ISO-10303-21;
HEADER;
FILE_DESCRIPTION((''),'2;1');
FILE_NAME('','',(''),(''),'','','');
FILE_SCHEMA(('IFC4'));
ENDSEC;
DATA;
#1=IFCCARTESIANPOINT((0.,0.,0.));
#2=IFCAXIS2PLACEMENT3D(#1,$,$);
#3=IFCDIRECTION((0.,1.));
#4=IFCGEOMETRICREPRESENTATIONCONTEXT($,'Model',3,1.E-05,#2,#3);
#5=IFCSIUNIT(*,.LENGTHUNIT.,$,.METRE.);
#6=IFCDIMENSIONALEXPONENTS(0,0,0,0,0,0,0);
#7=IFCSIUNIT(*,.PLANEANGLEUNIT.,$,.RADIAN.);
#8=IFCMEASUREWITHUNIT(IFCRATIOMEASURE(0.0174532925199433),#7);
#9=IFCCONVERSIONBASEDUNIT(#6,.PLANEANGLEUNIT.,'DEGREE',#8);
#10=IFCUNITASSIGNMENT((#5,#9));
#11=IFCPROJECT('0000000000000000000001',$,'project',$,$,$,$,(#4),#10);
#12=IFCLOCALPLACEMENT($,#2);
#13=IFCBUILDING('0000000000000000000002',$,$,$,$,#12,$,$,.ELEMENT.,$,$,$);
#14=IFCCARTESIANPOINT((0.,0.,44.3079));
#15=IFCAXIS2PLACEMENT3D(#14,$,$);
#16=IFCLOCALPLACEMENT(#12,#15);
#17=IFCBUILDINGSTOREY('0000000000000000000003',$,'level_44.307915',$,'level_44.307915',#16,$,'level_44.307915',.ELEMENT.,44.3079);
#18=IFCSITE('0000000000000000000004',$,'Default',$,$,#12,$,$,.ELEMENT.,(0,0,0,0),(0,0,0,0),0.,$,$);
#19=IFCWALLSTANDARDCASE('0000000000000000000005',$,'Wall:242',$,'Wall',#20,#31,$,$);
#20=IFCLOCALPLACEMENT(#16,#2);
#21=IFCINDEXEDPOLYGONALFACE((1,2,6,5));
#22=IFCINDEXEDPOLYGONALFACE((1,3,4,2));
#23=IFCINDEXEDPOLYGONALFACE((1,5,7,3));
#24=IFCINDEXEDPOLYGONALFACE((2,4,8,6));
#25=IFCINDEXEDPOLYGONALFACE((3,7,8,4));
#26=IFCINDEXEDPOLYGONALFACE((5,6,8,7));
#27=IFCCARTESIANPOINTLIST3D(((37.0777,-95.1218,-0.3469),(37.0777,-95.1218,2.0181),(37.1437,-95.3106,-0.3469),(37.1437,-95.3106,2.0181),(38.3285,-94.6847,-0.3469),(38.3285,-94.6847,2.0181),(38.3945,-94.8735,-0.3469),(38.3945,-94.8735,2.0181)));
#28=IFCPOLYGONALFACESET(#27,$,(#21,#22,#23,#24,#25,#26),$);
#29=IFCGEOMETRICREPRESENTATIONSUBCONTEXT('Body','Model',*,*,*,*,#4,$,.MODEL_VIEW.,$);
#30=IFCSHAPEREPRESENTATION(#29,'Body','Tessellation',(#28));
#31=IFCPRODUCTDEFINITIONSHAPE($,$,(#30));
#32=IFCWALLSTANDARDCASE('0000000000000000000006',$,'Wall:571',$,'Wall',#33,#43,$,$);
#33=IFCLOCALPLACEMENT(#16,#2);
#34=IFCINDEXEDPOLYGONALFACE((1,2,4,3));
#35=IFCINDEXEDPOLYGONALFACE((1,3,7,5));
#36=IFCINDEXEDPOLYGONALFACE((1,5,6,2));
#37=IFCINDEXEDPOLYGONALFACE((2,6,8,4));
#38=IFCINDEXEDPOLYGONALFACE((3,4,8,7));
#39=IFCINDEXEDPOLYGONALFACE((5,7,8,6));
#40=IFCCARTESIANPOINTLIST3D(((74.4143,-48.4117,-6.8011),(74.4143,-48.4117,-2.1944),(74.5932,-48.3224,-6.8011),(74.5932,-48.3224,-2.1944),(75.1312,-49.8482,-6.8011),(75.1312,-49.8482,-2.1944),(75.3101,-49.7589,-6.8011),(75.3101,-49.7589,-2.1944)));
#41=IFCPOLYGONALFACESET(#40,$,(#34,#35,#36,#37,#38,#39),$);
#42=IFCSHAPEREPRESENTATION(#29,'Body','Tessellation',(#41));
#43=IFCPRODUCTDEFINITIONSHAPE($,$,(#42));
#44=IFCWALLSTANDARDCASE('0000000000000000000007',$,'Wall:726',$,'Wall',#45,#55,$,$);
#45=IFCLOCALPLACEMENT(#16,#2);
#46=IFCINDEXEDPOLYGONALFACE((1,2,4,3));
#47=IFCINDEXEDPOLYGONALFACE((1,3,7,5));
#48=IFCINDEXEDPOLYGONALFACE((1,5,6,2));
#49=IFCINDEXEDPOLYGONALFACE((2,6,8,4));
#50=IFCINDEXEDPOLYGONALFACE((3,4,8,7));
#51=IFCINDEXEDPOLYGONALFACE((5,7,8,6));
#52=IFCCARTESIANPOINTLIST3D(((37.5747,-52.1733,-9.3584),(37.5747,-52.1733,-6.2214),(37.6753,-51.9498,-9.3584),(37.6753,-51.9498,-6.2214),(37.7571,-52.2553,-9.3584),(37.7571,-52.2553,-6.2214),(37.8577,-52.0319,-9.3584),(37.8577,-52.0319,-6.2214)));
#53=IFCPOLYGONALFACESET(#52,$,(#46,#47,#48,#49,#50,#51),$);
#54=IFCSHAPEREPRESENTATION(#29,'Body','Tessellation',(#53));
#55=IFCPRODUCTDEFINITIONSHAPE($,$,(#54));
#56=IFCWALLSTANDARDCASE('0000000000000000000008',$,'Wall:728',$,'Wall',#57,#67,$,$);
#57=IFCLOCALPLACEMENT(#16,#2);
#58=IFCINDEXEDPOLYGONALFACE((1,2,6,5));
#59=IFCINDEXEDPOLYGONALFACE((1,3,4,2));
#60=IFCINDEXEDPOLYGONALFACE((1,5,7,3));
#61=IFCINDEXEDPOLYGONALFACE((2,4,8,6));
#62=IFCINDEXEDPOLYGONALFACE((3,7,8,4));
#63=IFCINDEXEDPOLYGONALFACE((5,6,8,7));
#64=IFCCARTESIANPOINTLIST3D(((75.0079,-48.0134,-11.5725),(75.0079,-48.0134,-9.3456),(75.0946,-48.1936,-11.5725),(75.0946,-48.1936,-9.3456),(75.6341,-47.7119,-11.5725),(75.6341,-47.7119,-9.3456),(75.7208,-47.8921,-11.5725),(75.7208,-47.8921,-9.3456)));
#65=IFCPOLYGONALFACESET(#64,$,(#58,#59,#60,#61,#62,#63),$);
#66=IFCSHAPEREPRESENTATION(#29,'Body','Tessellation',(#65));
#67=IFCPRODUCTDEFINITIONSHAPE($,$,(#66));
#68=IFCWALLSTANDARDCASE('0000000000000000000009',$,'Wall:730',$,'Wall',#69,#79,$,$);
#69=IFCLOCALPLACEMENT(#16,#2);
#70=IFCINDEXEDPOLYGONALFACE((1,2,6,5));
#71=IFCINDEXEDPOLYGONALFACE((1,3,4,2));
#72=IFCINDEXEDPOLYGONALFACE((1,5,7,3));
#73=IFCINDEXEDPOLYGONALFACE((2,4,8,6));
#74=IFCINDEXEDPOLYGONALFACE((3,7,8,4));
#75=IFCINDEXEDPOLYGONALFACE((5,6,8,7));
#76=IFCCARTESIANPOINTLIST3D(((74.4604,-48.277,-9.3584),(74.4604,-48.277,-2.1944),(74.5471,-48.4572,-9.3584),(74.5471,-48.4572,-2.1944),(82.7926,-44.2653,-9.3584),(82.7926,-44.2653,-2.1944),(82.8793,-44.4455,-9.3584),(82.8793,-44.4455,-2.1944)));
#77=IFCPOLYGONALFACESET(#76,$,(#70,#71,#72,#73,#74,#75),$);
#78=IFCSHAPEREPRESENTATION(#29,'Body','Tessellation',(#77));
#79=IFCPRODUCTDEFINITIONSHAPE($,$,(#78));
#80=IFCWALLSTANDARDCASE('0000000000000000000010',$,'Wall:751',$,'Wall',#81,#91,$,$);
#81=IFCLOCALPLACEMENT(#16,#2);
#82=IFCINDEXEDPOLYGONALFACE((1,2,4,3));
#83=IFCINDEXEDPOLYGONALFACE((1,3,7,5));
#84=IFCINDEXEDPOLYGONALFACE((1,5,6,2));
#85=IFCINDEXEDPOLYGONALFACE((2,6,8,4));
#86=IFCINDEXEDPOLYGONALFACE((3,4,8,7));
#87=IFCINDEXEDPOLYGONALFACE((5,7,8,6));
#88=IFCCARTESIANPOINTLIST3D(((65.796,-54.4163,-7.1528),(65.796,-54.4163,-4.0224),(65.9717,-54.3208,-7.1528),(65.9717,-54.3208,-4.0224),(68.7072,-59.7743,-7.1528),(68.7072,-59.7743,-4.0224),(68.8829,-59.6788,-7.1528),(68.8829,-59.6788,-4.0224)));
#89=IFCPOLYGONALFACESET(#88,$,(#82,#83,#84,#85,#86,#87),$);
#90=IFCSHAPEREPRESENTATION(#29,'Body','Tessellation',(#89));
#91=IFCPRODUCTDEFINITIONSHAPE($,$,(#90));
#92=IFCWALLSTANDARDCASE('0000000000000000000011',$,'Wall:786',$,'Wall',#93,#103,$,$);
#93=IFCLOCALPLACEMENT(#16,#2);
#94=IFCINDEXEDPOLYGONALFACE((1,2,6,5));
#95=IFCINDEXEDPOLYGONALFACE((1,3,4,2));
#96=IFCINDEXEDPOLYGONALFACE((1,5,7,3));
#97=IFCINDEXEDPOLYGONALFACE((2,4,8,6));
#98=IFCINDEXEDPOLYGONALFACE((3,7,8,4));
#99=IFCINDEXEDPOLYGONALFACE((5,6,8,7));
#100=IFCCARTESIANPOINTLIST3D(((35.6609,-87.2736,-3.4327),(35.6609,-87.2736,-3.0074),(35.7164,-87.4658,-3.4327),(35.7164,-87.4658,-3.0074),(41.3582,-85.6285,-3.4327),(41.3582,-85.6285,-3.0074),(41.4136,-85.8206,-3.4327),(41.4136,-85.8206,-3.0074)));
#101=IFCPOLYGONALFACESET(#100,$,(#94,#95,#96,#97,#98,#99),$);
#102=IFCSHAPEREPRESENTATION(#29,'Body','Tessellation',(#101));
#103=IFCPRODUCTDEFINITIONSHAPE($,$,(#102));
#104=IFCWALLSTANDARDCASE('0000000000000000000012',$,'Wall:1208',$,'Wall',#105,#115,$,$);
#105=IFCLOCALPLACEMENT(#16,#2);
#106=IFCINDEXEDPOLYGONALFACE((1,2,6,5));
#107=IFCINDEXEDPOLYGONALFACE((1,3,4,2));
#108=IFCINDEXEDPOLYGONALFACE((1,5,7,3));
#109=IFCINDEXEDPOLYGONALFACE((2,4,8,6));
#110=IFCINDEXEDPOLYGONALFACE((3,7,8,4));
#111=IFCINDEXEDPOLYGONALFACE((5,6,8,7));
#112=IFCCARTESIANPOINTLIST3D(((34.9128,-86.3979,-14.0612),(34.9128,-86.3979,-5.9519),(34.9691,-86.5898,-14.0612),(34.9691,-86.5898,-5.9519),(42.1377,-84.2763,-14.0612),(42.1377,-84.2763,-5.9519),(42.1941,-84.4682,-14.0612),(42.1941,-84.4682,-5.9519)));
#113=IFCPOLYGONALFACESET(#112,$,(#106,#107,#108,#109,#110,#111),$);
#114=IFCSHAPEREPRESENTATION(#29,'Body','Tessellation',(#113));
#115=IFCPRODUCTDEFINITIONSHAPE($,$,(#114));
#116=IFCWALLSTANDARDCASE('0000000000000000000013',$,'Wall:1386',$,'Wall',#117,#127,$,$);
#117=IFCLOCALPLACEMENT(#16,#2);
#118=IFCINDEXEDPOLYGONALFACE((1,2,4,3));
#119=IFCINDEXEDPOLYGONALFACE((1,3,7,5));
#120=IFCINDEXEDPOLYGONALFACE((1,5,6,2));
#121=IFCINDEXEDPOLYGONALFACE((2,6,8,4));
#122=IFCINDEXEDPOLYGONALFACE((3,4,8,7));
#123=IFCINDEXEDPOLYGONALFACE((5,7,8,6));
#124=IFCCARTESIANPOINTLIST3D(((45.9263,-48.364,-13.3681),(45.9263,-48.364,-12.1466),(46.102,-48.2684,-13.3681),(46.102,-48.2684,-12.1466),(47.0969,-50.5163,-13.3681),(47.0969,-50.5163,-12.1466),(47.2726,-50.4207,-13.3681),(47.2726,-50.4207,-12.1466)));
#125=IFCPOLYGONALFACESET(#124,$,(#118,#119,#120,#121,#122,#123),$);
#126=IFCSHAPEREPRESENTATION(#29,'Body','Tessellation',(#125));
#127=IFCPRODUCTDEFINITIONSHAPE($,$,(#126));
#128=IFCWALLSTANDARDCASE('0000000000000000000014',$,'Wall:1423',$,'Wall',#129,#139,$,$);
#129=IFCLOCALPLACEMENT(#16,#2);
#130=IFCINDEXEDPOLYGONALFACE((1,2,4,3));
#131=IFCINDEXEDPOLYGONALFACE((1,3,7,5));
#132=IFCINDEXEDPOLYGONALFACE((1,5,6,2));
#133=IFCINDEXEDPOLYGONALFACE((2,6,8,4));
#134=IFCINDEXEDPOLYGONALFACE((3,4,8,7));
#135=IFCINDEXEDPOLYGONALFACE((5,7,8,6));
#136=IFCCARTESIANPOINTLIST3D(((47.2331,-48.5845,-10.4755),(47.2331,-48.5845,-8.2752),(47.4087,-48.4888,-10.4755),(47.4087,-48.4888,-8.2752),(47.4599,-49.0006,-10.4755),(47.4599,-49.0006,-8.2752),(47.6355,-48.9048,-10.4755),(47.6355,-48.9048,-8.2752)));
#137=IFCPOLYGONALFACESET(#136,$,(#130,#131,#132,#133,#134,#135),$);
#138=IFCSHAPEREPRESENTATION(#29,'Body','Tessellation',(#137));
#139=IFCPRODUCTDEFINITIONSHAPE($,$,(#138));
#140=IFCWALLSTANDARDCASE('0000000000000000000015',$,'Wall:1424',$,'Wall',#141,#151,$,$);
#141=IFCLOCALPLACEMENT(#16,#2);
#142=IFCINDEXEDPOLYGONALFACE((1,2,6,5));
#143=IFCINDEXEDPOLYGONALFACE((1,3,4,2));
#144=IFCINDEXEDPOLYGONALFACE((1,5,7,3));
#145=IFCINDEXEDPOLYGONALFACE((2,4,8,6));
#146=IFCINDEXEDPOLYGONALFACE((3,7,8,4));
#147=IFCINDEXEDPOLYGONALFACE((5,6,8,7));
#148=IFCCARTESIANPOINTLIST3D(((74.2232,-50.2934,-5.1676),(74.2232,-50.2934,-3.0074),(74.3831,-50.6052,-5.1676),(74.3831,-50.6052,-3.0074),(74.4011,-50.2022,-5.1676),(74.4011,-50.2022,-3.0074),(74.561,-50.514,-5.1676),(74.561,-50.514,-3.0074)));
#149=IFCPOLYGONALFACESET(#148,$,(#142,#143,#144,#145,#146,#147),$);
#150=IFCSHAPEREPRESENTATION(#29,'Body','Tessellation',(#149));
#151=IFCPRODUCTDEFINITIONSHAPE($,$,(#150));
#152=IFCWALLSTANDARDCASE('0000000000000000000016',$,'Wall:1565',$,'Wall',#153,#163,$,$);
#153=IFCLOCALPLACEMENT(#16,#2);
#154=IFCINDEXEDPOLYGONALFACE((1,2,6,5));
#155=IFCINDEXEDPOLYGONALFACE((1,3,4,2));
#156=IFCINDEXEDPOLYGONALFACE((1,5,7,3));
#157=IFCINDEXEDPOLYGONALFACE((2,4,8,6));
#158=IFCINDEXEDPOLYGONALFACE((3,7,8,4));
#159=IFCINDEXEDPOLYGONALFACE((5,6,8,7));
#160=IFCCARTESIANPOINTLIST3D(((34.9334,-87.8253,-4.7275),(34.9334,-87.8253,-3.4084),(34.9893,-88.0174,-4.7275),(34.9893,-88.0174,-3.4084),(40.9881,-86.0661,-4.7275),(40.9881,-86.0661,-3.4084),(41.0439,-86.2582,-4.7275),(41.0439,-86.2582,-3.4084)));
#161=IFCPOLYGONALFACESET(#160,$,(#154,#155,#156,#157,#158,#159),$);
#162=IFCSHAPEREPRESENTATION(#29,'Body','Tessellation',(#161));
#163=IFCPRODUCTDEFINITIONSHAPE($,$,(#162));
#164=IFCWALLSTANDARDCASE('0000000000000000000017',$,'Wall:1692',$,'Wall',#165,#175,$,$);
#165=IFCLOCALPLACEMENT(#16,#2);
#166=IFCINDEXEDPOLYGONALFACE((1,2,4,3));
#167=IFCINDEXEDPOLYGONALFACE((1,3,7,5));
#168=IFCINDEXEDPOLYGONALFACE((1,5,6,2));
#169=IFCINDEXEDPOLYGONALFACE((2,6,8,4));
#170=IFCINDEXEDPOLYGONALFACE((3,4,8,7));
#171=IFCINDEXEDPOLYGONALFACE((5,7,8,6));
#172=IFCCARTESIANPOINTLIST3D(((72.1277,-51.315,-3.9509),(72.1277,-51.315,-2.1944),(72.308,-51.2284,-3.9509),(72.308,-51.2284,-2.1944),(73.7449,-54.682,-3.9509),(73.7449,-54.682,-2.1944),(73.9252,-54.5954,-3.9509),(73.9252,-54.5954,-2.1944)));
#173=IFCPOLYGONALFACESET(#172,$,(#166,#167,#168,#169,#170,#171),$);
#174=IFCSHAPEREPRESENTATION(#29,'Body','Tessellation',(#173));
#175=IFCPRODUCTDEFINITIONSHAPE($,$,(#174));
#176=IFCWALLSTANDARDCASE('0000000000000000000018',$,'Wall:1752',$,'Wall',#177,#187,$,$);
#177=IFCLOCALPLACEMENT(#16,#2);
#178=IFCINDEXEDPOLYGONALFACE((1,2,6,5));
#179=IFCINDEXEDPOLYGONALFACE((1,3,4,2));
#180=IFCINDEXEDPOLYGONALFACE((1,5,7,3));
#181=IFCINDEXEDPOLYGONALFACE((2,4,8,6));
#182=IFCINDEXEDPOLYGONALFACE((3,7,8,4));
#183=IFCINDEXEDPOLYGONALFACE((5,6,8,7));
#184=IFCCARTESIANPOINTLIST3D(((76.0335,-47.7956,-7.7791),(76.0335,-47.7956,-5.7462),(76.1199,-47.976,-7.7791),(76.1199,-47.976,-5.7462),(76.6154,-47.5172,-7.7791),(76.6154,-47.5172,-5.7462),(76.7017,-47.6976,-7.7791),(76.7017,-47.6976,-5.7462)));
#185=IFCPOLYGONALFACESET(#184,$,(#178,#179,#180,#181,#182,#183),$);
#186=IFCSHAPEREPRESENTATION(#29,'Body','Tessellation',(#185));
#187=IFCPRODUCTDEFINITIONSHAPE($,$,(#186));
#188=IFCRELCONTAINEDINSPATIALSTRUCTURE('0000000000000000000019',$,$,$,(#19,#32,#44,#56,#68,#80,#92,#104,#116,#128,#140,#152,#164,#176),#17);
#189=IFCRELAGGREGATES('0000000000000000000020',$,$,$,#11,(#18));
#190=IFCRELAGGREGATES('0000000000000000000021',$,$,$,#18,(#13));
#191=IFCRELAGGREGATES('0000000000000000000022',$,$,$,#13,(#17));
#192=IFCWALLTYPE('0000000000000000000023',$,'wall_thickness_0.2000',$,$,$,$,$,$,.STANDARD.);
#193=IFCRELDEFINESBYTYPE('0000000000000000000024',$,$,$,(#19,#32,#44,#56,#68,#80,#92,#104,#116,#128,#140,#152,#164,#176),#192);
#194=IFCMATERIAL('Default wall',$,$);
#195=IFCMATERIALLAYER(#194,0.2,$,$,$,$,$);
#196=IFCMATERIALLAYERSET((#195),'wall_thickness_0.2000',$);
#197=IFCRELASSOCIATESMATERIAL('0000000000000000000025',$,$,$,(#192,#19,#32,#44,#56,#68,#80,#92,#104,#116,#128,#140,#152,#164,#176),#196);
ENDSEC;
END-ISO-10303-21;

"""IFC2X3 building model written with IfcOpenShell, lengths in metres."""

from ifc_helpers import new_model, entity, si_unit, converted_unit, direction, frame, origin, place, context, subcontext, project, spatial, polyline, outline, extrude, material, layer, layer_set, layer_usage, type_object, element, save


model = new_model("IFC2X3")

# Units and contexts
model_context = context("Model", 3, precision=1e-05, world=origin(), true_north=direction((0.0, 1.0)))
body_context = subcontext(model_context, "Body", "Model", "MODEL_VIEW")
ifc_project = project(units=[si_unit("LENGTHUNIT", "METRE"), converted_unit("PLANEANGLEUNIT", "DEGREE", entity("IfcRatioMeasure", 0.0174532925199433), si_unit("PLANEANGLEUNIT", "RADIAN"), dimensions=[0, 0, 0, 0, 0, 0, 0])], contexts=[model_context])

# Site, building, storey
placement_1 = place(None, origin())
site = spatial("IfcSite", under=ifc_project, at=placement_1, Name="Default", CompositionType="ELEMENT", RefLatitude=(0, 0, 0, 0), RefLongitude=(0, 0, 0, 0), RefElevation=0.0)
building = spatial("IfcBuilding", under=site, at=placement_1, CompositionType="ELEMENT")
storey_placement = place(placement_1, frame((0.0, 0.0, 44.3079)))
storey = spatial("IfcBuildingStorey", under=building, at=storey_placement, Name="level_44.307915", ObjectType="level_44.307915", LongName="level_44.307915", CompositionType="ELEMENT", Elevation=44.3079)

# Walls
ifc_material_1 = material(Name="Default wall")
ifc_layer = layer(ifc_material_1, 0.2)
ifc_layer_set = layer_set([ifc_layer], Name="wall_thickness_0.2000")
ifc_layer_usage = layer_usage(ifc_layer_set, "AXIS2", "POSITIVE", -0.1)
wall_type = type_object("IfcWallType", Name="wall_thickness_0.2000", PredefinedType="STANDARD", material=ifc_layer_set)
placement_2 = place(placement_1, frame((0.0, 0.0, 43.961)))
wall_1_placement = place(placement_2, frame((37.1107, -95.2162, 0.0), z_axis=(0.0, 0.0, 1.0), x_axis=(0.944006, 0.329929, 0.0)))
element("IfcWallStandardCase", 1, at=wall_1_placement, inside=storey, type_object=wall_type, material=ifc_layer_usage, Name="Wall:242", ObjectType="Wall", context=body_context, shape_type="SweptSolid", body=[
    extrude(outline(polyline([(1.325, -0.1), (1.325, 0.1), (0.0, 0.1), (0.0, -0.1), (1.325, -0.1)])), origin(), (0.0, 0.0, 1.0), 2.365),
])
placement_3 = place(placement_1, frame((0.0, 0.0, 37.5068)))
wall_2_placement = place(placement_3, frame((75.2207, -49.8036, 0.0), z_axis=(0.0, 0.0, 1.0), x_axis=(-0.446537, 0.894765, 0.0)))
element("IfcWallStandardCase", 2, at=wall_2_placement, inside=storey, type_object=wall_type, material=ifc_layer_usage, Name="Wall:571", ObjectType="Wall", context=body_context, shape_type="SweptSolid", body=[
    extrude(outline(polyline([(1.6055, -0.1), (1.6055, 0.1), (0.0, 0.1), (0.0, -0.1), (1.6055, -0.1)])), origin(), (0.0, 0.0, 1.0), 4.6068),
])
placement_4 = place(placement_1, frame((0.0, 0.0, 34.9495)))
wall_3_placement = place(placement_4, frame((37.7665, -51.9909, 0.0), z_axis=(0.0, 0.0, 1.0), x_axis=(-0.410319, -0.911942, 0.0)))
element("IfcWallStandardCase", 3, at=wall_3_placement, inside=storey, type_object=wall_type, material=ifc_layer_usage, Name="Wall:726", ObjectType="Wall", context=body_context, shape_type="SweptSolid", body=[
    extrude(outline(polyline([(0.245, -0.1), (0.245, 0.1), (0.0, 0.1), (0.0, -0.1), (0.245, -0.1)])), origin(), (0.0, 0.0, 1.0), 3.137),
])
placement_5 = place(placement_1, frame((0.0, 0.0, 32.7354)))
wall_4_placement = place(placement_5, frame((75.0512, -48.1035, 0.0), z_axis=(0.0, 0.0, 1.0), x_axis=(0.901006, 0.433806, 0.0)))
element("IfcWallStandardCase", 4, at=wall_4_placement, inside=storey, type_object=wall_type, material=ifc_layer_usage, Name="Wall:728", ObjectType="Wall", context=body_context, shape_type="SweptSolid", body=[
    extrude(outline(polyline([(0.695, -0.1), (0.695, 0.1), (0.0, 0.1), (0.0, -0.1), (0.695, -0.1)])), origin(), (0.0, 0.0, 1.0), 2.2268),
])
placement_6 = place(placement_1, frame((0.0, 0.0, 34.9495)))
wall_5_placement = place(placement_6, frame((74.5038, -48.3671, 0.0), z_axis=(0.0, 0.0, 1.0), x_axis=(0.901007, 0.433805, 0.0)))
element("IfcWallStandardCase", 5, at=wall_5_placement, inside=storey, type_object=wall_type, material=ifc_layer_usage, Name="Wall:730", ObjectType="Wall", context=body_context, shape_type="SweptSolid", body=[
    extrude(outline(polyline([(9.2476, -0.1), (9.2476, 0.1), (0.0, 0.1), (0.0, -0.1), (9.2476, -0.1)])), origin(), (0.0, 0.0, 1.0), 7.164),
])
placement_7 = place(placement_1, frame((0.0, 0.0, 37.1551)))
wall_6_placement = place(placement_7, frame((65.8838, -54.3685, 0.0), z_axis=(0.0, 0.0, 1.0), x_axis=(0.477416, -0.878677, 0.0)))
element("IfcWallStandardCase", 6, at=wall_6_placement, inside=storey, type_object=wall_type, material=ifc_layer_usage, Name="Wall:751", ObjectType="Wall", context=body_context, shape_type="SweptSolid", body=[
    extrude(outline(polyline([(6.0978, -0.1), (6.0978, 0.1), (0.0, 0.1), (0.0, -0.1), (6.0978, -0.1)])), origin(), (0.0, 0.0, 1.0), 3.1304),
])
placement_8 = place(placement_1, frame((0.0, 0.0, 40.8752)))
wall_7_placement = place(placement_8, frame((35.6887, -87.3697, 0.0), z_axis=(0.0, 0.0, 1.0), x_axis=(0.960748, 0.277422, 0.0)))
element("IfcWallStandardCase", 7, at=wall_7_placement, inside=storey, type_object=wall_type, material=ifc_layer_usage, Name="Wall:786", ObjectType="Wall", context=body_context, shape_type="SweptSolid", body=[
    extrude(outline(polyline([(5.93, -0.1), (5.93, 0.1), (0.0, 0.1), (0.0, -0.1), (5.93, -0.1)])), origin(), (0.0, 0.0, 1.0), 0.4253),
])
placement_9 = place(placement_1, frame((0.0, 0.0, 30.2467)))
wall_8_placement = place(placement_9, frame((34.941, -86.4939, 0.0), z_axis=(0.0, 0.0, 1.0), x_axis=(0.959485, 0.28176, 0.0)))
element("IfcWallStandardCase", 8, at=wall_8_placement, inside=storey, type_object=wall_type, material=ifc_layer_usage, Name="Wall:1208", ObjectType="Wall", context=body_context, shape_type="SweptSolid", body=[
    extrude(outline(polyline([(7.53, -0.1), (7.53, 0.1), (0.0, 0.1), (0.0, -0.1), (7.53, -0.1)])), origin(), (0.0, 0.0, 1.0), 8.1093),
])
placement_10 = place(placement_1, frame((0.0, 0.0, 30.9398)))
wall_9_placement = place(placement_10, frame((46.0142, -48.3162, 0.0), z_axis=(0.0, 0.0, 1.0), x_axis=(0.477798, -0.87847, 0.0)))
element("IfcWallStandardCase", 9, at=wall_9_placement, inside=storey, type_object=wall_type, material=ifc_layer_usage, Name="Wall:1386", ObjectType="Wall", context=body_context, shape_type="SweptSolid", body=[
    extrude(outline(polyline([(2.45, -0.1), (2.45, 0.1), (0.0, 0.1), (0.0, -0.1), (2.45, -0.1)])), origin(), (0.0, 0.0, 1.0), 1.2215),
])
placement_11 = place(placement_1, frame((0.0, 0.0, 33.8324)))
wall_10_placement = place(placement_11, frame((47.5477, -48.9527, 0.0), z_axis=(0.0, 0.0, 1.0), x_axis=(-0.478686, 0.877986, 0.0)))
element("IfcWallStandardCase", 10, at=wall_10_placement, inside=storey, type_object=wall_type, material=ifc_layer_usage, Name="Wall:1423", ObjectType="Wall", context=body_context, shape_type="SweptSolid", body=[
    extrude(outline(polyline([(0.4739, -0.1), (0.4739, 0.1), (0.0, 0.1), (0.0, -0.1), (0.4739, -0.1)])), origin(), (0.0, 0.0, 1.0), 2.2003),
])
placement_12 = place(placement_1, frame((0.0, 0.0, 39.1403)))
wall_11_placement = place(placement_12, frame((74.472, -50.5596, 0.0), z_axis=(0.0, 0.0, 1.0), x_axis=(-0.456261, 0.889846, 0.0)))
element("IfcWallStandardCase", 11, at=wall_11_placement, inside=storey, type_object=wall_type, material=ifc_layer_usage, Name="Wall:1424", ObjectType="Wall", context=body_context, shape_type="SweptSolid", body=[
    extrude(outline(polyline([(0.3504, -0.1), (0.3504, 0.1), (0.0, 0.1), (0.0, -0.1), (0.3504, -0.1)])), origin(), (0.0, 0.0, 1.0), 2.1602),
])
placement_13 = place(placement_1, frame((0.0, 0.0, 39.5804)))
wall_12_placement = place(placement_13, frame((34.9613, -87.9214, 0.0), z_axis=(0.0, 0.0, 1.0), x_axis=(0.960286, 0.279017, 0.0)))
element("IfcWallStandardCase", 12, at=wall_12_placement, inside=storey, type_object=wall_type, material=ifc_layer_usage, Name="Wall:1565", ObjectType="Wall", context=body_context, shape_type="SweptSolid", body=[
    extrude(outline(polyline([(6.305, -0.1), (6.305, 0.1), (0.0, 0.1), (0.0, -0.1), (6.305, -0.1)])), origin(), (0.0, 0.0, 1.0), 1.319),
])
placement_14 = place(placement_1, frame((0.0, 0.0, 40.357)))
wall_13_placement = place(placement_14, frame((72.2178, -51.2717, 0.0), z_axis=(0.0, 0.0, 1.0), x_axis=(0.432959, -0.901413, 0.0)))
element("IfcWallStandardCase", 13, at=wall_13_placement, inside=storey, type_object=wall_type, material=ifc_layer_usage, Name="Wall:1692", ObjectType="Wall", context=body_context, shape_type="SweptSolid", body=[
    extrude(outline(polyline([(3.7352, -0.1), (3.7352, 0.1), (0.0, 0.1), (0.0, -0.1), (3.7352, -0.1)])), origin(), (0.0, 0.0, 1.0), 1.7565),
])
placement_15 = place(placement_1, frame((0.0, 0.0, 36.5288)))
wall_14_placement = place(placement_15, frame((76.0767, -47.8858, 0.0), z_axis=(0.0, 0.0, 1.0), x_axis=(0.90205, 0.431632, 0.0)))
element("IfcWallStandardCase", 14, at=wall_14_placement, inside=storey, type_object=wall_type, material=ifc_layer_usage, Name="Wall:1752", ObjectType="Wall", context=body_context, shape_type="SweptSolid", body=[
    extrude(outline(polyline([(0.645, -0.1), (0.645, 0.1), (0.0, 0.1), (0.0, -0.1), (0.645, -0.1)])), origin(), (0.0, 0.0, 1.0), 2.0329),
])

save(model, "model.ifc")
